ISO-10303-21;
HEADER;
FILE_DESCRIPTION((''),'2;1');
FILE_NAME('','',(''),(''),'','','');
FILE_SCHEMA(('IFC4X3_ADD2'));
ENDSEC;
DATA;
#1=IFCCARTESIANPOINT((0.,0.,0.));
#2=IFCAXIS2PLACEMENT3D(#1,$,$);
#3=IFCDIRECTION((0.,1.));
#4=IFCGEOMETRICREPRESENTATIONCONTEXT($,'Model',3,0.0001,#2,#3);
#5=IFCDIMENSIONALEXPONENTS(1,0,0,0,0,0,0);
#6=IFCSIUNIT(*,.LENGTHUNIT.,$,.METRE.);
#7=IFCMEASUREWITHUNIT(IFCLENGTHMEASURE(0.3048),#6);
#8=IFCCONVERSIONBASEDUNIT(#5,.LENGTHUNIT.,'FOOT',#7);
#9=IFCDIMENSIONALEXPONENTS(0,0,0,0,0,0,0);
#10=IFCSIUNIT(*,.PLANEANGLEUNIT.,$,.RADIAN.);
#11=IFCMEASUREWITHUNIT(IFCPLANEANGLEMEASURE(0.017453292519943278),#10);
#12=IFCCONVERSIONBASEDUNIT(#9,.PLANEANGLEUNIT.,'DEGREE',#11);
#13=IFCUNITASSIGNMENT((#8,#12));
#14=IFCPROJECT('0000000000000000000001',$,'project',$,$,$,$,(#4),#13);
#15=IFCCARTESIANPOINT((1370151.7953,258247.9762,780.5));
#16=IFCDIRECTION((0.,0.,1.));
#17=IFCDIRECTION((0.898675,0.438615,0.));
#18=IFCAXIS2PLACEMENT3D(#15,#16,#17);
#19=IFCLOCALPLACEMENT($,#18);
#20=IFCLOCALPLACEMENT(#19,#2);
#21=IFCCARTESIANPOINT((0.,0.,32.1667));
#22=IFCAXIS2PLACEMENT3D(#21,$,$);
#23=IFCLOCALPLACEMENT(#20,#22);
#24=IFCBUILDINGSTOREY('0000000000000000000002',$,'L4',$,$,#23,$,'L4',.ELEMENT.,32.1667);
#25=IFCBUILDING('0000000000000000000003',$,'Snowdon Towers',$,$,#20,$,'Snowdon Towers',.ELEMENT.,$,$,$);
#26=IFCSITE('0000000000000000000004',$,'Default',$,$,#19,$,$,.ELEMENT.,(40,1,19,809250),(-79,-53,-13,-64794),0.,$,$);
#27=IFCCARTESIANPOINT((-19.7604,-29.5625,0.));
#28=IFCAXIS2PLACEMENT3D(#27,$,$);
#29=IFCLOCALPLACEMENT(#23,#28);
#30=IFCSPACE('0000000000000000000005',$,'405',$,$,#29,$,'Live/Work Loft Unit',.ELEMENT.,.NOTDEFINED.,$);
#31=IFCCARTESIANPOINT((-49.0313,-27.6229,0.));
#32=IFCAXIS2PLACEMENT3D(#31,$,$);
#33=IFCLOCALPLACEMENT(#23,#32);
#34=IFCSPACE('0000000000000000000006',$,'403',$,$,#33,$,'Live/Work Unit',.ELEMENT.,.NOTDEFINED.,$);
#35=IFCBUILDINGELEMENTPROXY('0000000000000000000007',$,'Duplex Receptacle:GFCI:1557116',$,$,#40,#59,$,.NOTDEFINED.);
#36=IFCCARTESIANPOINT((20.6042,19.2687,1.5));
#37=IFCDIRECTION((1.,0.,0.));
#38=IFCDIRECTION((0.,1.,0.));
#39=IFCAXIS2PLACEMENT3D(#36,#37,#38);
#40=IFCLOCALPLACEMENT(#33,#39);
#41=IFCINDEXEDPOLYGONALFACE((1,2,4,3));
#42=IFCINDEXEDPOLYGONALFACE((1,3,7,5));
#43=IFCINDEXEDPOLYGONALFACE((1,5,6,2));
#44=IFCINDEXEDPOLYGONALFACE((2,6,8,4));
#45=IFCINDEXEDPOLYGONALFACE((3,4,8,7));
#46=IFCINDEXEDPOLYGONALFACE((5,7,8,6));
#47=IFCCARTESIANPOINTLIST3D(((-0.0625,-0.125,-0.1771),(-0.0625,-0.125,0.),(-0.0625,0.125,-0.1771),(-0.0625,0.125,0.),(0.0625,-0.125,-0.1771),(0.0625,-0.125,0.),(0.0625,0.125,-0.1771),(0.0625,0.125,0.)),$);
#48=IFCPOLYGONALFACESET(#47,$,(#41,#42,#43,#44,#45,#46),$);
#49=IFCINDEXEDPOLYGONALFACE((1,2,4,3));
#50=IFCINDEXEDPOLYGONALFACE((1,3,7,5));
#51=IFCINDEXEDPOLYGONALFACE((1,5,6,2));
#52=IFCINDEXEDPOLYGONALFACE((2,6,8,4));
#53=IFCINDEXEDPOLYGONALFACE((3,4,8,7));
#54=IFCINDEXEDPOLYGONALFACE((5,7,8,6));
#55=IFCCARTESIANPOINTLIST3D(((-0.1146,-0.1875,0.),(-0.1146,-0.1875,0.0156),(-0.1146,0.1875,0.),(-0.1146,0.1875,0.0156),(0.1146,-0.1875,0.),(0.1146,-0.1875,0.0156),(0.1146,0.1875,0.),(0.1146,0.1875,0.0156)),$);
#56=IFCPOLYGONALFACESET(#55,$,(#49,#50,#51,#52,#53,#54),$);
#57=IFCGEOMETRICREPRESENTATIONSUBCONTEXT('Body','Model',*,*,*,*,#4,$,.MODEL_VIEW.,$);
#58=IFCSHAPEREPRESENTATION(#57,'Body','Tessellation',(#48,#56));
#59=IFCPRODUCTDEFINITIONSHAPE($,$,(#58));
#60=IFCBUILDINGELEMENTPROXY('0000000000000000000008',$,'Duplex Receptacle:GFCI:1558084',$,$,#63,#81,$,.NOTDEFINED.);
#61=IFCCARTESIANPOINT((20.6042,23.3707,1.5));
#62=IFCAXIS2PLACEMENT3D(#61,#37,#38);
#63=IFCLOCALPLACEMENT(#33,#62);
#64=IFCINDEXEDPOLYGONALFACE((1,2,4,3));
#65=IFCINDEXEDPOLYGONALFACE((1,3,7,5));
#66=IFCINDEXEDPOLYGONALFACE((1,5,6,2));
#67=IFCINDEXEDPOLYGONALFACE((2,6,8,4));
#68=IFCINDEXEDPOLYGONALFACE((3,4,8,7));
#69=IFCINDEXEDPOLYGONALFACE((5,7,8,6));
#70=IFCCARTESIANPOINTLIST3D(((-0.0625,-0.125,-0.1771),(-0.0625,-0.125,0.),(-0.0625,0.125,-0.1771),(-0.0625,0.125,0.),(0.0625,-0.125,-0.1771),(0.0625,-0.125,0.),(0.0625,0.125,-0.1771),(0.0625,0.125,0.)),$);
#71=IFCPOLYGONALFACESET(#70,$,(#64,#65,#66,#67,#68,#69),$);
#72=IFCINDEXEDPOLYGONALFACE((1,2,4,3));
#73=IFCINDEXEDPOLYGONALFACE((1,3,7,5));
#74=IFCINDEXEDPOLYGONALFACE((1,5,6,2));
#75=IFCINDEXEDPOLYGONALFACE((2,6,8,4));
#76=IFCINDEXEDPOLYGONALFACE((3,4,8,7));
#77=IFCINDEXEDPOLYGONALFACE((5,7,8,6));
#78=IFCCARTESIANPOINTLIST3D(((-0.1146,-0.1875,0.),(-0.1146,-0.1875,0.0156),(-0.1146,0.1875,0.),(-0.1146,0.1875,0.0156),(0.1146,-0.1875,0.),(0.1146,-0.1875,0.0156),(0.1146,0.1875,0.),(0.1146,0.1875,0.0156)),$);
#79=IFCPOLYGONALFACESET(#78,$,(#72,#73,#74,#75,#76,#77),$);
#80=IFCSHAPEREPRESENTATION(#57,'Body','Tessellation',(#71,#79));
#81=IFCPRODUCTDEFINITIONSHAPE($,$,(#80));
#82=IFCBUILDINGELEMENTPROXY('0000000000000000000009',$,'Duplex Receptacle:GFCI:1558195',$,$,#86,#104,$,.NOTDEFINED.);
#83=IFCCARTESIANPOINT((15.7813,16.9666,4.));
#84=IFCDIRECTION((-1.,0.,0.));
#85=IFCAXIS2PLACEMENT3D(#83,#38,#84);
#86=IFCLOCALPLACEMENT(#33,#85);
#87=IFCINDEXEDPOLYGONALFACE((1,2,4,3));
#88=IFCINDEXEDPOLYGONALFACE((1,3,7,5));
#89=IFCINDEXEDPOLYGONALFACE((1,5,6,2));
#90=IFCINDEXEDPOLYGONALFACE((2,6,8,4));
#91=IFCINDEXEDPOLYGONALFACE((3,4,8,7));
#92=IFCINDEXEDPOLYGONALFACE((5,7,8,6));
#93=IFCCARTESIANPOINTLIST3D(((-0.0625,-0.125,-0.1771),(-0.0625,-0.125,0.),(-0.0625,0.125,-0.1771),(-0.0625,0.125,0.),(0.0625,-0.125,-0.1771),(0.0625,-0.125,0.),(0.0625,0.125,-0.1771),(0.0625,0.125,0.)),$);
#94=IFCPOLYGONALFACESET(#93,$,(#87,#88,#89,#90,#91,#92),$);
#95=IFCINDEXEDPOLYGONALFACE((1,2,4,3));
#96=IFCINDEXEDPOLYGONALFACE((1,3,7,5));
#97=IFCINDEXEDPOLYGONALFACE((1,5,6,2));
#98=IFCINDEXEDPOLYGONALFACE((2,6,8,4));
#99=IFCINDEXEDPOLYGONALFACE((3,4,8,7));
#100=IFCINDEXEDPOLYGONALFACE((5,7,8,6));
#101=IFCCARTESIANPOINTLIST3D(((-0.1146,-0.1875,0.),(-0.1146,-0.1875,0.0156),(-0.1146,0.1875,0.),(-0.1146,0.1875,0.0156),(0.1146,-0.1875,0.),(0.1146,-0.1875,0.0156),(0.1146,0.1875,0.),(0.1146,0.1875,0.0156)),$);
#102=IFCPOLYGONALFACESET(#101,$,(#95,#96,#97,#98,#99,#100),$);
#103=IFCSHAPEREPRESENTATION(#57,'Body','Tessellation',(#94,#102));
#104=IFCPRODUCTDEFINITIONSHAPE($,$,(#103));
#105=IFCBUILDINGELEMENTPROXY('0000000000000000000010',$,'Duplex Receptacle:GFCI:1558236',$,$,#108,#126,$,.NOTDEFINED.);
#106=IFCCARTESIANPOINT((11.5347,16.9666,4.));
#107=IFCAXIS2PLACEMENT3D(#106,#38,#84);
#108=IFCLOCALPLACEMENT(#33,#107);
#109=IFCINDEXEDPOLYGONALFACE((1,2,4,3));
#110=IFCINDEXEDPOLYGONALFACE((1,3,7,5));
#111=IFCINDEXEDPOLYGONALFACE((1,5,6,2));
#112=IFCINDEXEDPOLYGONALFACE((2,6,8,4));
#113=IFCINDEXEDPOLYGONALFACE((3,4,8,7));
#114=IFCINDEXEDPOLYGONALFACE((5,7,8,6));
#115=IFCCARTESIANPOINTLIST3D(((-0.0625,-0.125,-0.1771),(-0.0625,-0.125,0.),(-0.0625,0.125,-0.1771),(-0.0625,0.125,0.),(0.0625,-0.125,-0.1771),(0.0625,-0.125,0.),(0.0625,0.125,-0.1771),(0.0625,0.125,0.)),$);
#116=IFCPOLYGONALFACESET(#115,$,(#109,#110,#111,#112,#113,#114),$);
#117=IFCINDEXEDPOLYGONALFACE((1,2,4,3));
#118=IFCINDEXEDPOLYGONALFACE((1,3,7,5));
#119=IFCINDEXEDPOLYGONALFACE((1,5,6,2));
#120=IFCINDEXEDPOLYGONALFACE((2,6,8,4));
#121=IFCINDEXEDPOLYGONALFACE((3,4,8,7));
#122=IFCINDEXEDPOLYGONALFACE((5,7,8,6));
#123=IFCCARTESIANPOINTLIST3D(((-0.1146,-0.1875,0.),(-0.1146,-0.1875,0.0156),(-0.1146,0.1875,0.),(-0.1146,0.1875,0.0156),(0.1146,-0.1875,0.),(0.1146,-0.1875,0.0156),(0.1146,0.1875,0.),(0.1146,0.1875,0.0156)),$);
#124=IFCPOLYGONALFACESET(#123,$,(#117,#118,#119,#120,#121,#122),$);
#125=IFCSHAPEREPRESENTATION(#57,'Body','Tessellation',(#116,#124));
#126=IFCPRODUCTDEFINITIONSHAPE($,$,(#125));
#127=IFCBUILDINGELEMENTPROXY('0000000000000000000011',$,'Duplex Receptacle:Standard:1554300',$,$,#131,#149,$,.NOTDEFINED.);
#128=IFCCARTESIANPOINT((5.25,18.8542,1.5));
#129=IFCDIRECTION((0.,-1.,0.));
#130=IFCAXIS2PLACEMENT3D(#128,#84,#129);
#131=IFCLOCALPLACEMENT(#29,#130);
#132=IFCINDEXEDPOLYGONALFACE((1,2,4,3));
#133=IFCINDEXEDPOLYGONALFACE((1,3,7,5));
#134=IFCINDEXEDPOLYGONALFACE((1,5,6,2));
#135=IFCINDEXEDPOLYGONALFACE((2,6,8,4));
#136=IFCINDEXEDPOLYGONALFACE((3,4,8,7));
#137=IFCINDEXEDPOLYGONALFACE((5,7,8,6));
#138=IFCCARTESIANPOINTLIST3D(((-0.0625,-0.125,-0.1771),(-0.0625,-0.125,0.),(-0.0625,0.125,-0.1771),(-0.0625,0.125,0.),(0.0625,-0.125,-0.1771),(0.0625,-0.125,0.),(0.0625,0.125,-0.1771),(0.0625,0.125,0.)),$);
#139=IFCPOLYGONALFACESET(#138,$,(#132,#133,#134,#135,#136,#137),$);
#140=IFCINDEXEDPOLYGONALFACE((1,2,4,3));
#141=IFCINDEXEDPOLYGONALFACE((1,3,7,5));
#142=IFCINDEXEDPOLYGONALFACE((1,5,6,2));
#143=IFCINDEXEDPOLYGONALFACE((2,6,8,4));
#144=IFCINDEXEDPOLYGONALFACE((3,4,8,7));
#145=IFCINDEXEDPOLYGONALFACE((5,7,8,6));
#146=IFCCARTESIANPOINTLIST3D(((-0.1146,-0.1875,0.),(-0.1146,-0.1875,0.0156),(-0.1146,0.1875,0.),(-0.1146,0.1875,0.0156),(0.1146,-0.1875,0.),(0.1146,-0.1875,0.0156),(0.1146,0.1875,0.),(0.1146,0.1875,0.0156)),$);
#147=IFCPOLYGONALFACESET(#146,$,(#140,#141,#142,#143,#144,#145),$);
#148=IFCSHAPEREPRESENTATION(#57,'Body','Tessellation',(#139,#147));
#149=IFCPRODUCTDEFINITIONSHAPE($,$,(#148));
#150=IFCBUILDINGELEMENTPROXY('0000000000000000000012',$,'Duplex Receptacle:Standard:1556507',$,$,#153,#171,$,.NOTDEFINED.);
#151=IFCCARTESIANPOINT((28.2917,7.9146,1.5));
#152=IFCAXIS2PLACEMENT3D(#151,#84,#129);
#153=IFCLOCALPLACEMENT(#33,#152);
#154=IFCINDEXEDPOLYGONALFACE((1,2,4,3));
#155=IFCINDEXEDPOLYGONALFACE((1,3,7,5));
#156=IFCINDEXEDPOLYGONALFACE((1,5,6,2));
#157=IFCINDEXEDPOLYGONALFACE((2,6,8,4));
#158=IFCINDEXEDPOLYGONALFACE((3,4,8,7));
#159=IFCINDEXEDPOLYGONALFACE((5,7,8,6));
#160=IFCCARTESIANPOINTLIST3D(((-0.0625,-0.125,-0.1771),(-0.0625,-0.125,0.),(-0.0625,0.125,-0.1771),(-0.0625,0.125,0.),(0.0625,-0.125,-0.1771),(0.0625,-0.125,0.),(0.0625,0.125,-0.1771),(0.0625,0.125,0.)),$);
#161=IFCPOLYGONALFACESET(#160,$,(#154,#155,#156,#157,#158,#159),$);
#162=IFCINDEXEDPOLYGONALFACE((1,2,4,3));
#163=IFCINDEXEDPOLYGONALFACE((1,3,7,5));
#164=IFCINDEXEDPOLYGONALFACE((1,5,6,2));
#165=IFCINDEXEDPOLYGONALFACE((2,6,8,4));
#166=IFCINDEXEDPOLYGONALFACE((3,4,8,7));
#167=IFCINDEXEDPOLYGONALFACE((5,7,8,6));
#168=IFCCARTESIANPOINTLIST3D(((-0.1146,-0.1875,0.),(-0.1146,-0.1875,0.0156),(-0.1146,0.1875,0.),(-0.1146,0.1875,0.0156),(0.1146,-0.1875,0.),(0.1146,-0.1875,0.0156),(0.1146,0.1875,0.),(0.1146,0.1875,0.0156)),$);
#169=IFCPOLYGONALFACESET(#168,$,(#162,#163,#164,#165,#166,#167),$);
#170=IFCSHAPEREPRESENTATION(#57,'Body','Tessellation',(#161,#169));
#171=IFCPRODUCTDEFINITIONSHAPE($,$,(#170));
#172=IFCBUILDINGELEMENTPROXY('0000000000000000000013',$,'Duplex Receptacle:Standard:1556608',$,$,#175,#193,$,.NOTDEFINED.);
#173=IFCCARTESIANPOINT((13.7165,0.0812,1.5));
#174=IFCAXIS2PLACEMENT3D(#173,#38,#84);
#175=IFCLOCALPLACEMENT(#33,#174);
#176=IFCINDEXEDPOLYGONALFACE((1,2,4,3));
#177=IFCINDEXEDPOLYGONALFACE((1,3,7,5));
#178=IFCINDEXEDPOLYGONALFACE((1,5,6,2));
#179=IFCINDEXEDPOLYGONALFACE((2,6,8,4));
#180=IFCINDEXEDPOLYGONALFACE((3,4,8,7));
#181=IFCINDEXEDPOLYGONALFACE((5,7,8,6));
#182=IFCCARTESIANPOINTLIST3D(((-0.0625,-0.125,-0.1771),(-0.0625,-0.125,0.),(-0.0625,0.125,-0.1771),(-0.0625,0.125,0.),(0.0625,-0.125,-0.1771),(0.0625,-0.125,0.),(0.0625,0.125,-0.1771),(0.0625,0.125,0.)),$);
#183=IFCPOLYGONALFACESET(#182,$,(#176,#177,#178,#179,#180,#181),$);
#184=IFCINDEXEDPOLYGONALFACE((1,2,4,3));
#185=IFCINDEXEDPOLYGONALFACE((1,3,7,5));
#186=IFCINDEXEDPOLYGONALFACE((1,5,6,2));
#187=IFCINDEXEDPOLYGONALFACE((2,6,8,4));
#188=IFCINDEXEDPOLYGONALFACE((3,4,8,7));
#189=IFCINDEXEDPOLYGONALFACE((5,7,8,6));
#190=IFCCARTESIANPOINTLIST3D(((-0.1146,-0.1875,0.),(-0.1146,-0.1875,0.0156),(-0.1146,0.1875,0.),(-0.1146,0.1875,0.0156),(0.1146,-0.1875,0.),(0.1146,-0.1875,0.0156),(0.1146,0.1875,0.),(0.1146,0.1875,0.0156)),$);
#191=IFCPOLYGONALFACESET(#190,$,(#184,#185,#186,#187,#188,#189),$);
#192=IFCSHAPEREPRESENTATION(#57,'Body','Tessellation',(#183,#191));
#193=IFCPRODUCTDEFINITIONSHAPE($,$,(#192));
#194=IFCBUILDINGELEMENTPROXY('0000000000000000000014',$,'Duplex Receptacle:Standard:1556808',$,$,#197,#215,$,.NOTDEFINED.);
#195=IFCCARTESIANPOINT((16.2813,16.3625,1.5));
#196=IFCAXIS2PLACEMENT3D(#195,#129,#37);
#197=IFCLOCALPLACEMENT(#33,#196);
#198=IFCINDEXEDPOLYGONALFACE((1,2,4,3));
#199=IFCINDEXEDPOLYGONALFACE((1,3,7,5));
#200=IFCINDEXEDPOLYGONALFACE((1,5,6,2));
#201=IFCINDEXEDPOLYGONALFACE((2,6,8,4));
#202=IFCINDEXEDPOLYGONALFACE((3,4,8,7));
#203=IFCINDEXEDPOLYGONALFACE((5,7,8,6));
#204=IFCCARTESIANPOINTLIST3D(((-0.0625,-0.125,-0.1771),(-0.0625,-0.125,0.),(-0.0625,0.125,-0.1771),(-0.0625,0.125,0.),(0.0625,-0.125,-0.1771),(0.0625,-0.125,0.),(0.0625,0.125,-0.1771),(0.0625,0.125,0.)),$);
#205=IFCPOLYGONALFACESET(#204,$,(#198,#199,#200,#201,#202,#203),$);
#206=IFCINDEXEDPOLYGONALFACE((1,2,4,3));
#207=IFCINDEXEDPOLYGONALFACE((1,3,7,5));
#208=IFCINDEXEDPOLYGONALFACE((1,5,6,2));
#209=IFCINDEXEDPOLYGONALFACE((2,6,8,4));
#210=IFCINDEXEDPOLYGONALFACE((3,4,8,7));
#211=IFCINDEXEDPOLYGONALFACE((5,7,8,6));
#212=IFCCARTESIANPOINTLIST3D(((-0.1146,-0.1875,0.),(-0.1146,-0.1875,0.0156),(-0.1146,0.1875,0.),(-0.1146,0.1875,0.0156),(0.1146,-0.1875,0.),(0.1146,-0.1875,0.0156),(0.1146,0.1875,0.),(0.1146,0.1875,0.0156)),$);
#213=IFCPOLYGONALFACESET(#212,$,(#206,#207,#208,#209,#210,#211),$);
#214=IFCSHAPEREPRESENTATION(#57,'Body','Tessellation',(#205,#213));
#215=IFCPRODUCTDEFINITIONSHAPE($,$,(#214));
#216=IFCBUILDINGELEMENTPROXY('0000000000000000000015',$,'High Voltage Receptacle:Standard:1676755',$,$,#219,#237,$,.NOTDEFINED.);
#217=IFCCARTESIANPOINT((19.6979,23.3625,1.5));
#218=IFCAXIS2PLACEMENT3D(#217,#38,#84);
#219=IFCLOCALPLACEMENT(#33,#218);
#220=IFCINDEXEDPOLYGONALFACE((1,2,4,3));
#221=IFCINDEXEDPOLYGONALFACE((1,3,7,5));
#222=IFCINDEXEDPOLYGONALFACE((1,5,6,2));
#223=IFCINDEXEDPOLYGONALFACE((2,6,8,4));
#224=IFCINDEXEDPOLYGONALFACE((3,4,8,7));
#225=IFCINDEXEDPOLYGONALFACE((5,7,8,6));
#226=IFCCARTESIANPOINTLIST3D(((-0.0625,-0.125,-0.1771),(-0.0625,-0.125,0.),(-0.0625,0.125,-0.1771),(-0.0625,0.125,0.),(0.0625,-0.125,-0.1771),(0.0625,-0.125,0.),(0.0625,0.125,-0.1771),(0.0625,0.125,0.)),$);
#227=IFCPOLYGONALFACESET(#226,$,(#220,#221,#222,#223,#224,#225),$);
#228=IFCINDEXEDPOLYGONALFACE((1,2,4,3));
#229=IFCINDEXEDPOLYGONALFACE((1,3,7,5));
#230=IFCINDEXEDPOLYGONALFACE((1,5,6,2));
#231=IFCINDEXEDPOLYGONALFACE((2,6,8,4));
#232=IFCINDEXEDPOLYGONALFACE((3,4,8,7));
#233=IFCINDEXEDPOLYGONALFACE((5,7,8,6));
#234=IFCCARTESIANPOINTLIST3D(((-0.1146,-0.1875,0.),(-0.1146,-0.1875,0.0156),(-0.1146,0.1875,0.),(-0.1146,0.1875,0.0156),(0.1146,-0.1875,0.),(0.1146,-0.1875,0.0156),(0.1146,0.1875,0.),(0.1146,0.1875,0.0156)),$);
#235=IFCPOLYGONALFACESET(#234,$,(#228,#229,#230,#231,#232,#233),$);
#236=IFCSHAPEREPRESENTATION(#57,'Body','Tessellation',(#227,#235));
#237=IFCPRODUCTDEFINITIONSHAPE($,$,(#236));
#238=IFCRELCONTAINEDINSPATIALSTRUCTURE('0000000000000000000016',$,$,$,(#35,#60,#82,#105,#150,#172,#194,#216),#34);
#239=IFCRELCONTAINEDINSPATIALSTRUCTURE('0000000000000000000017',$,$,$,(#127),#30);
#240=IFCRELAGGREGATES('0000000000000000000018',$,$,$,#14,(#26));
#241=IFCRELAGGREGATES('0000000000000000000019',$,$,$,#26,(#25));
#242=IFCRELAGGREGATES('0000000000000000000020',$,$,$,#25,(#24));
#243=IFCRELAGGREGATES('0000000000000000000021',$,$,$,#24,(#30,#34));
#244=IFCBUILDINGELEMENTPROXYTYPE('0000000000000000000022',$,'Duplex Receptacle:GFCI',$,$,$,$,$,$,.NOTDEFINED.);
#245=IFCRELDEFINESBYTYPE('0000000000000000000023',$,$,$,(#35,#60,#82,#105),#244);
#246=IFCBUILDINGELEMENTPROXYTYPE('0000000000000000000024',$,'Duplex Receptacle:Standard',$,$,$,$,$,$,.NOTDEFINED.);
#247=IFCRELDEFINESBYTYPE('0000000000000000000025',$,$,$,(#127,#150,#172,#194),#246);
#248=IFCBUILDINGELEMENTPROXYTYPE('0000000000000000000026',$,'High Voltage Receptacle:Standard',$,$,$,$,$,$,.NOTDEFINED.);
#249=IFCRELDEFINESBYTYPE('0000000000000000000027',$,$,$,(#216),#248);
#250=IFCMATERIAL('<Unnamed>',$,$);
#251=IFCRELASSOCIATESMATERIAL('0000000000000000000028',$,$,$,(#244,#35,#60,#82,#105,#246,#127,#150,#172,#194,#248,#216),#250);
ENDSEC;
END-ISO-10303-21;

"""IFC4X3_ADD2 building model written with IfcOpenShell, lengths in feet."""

from ifc_helpers import new_model, entity, si_unit, converted_unit, direction, frame, frame_2d, origin, origin_2d_with_axis, place, context, subcontext, project, spatial, rectangle, extrude, source, transform, mapped, material, type_object, type_shapes, element, save


model = new_model("IFC4X3_ADD2")

# Units and contexts
model_context = context("Model", 3, precision=0.0001, world=origin(), true_north=direction((0.0, 1.0)))
body_context = subcontext(model_context, "Body", "Model", "MODEL_VIEW")
ifc_project = project(units=[converted_unit("LENGTHUNIT", "FOOT", entity("IfcLengthMeasure", 0.3048), si_unit("LENGTHUNIT", "METRE"), dimensions=[1, 0, 0, 0, 0, 0, 0]), converted_unit("PLANEANGLEUNIT", "DEGREE", entity("IfcPlaneAngleMeasure", 0.017453292519943278), si_unit("PLANEANGLEUNIT", "RADIAN"), dimensions=[0, 0, 0, 0, 0, 0, 0])], contexts=[model_context])

# Site, building, storey, space
site_placement = place(None, frame((1370151.7953, 258247.9762, 780.5), z_axis=(0.0, 0.0, 1.0), x_axis=(0.898675, 0.438615, 0.0)))
site = spatial("IfcSite", under=ifc_project, at=site_placement, Name="Default", CompositionType="ELEMENT", RefLatitude=(40, 1, 19, 809250), RefLongitude=(-79, -53, -13, -64794), RefElevation=0.0)
building_placement = place(site_placement, origin())
building = spatial("IfcBuilding", under=site, at=building_placement, Name="Snowdon Towers", LongName="Snowdon Towers", CompositionType="ELEMENT")
storey_placement = place(building_placement, frame((0.0, 0.0, 32.1667)))
storey = spatial("IfcBuildingStorey", under=building, at=storey_placement, Name="L4", LongName="L4", CompositionType="ELEMENT", Elevation=32.1667)
space_1_placement = place(storey_placement, frame((-19.7604, -29.5625, 0.0)))
space_1 = spatial("IfcSpace", under=storey, at=space_1_placement, Name="405", LongName="Live/Work Loft Unit", CompositionType="ELEMENT", PredefinedType="NOTDEFINED")

# Shared definitions
ifc_material_1 = material(Name="<Unnamed>")

# Shared definitions
space_2_placement = place(storey_placement, frame((-49.0313, -27.6229, 0.0)))
space_2 = spatial("IfcSpace", under=storey, at=space_2_placement, Name="403", LongName="Live/Work Unit", CompositionType="ELEMENT", PredefinedType="NOTDEFINED")

# Building element proxies
building_element_proxy_type_1 = type_object("IfcBuildingElementProxyType", Name="Duplex Receptacle:GFCI", PredefinedType="NOTDEFINED", material=ifc_material_1)
shared_shape_1 = source(origin(), body_context, "Body", "SweptSolid", [
    extrude(rectangle(XDim=0.125, YDim=0.25, at=origin_2d_with_axis()), frame((0.0, 0.0, -0.1771), z_axis=(0.0, 0.0, 1.0), x_axis=(-1.0, 0.0, 0.0)), (0.0, 0.0, 1.0), 0.1771),
    extrude(rectangle(XDim=0.2292, YDim=0.375, at=frame_2d((0.0, 0.0), x_axis=(1.0, 0.0))), frame((0.0, 0.0, 0.0), z_axis=(0.0, 0.0, 1.0), x_axis=(-1.0, 0.0, 0.0)), (0.0, 0.0, 1.0), 0.0156),
])
type_shapes(building_element_proxy_type_1, [shared_shape_1])
for number, where, z_axis, x_axis, name in (
    (1, (20.6042, 19.2687, 1.5), (1.0, 0.0, 0.0), (0.0, 1.0, 0.0), "Duplex Receptacle:GFCI:1557116"),
    (2, (20.6042, 23.3707, 1.5), (1.0, 0.0, 0.0), (0.0, 1.0, 0.0), "Duplex Receptacle:GFCI:1558084"),
    (3, (15.7813, 16.9666, 4.0), (0.0, 1.0, 0.0), (-1.0, 0.0, 0.0), "Duplex Receptacle:GFCI:1558195"),
    (4, (11.5347, 16.9666, 4.0), (0.0, 1.0, 0.0), (-1.0, 0.0, 0.0), "Duplex Receptacle:GFCI:1558236"),
):
    element("IfcBuildingElementProxy", number, at=place(space_2_placement, frame(where, z_axis=z_axis, x_axis=x_axis)), inside=space_2, type_object=building_element_proxy_type_1, material=ifc_material_1, Name=name, PredefinedType="NOTDEFINED", context=body_context, shape_type="MappedRepresentation", body=[
        mapped(shared_shape_1, transform((0.0, 0.0, 0.0), scale=1.0)),
    ])
building_element_proxy_type_2 = type_object("IfcBuildingElementProxyType", Name="Duplex Receptacle:Standard", PredefinedType="NOTDEFINED", material=ifc_material_1)
shared_shape_2 = source(origin(), body_context, "Body", "SweptSolid", [
    extrude(rectangle(XDim=0.125, YDim=0.25, at=origin_2d_with_axis()), frame((0.0, 0.0, -0.1771), z_axis=(0.0, 0.0, 1.0), x_axis=(-1.0, 0.0, 0.0)), (0.0, 0.0, 1.0), 0.1771),
    extrude(rectangle(XDim=0.2292, YDim=0.375, at=frame_2d((0.0, 0.0), x_axis=(1.0, 0.0))), frame((0.0, 0.0, 0.0), z_axis=(0.0, 0.0, 1.0), x_axis=(-1.0, 0.0, 0.0)), (0.0, 0.0, 1.0), 0.0156),
])
type_shapes(building_element_proxy_type_2, [shared_shape_2])
for number, where, z_axis, x_axis, name in (
    (5, (5.25, 18.8542, 1.5), (-1.0, 0.0, 0.0), (0.0, -1.0, 0.0), "Duplex Receptacle:Standard:1554300"),
):
    element("IfcBuildingElementProxy", number, at=place(space_1_placement, frame(where, z_axis=z_axis, x_axis=x_axis)), inside=space_1, type_object=building_element_proxy_type_2, material=ifc_material_1, Name=name, PredefinedType="NOTDEFINED", context=body_context, shape_type="MappedRepresentation", body=[
        mapped(shared_shape_2, transform((0.0, 0.0, 0.0), scale=1.0)),
    ])
for number, where, z_axis, x_axis, name in (
    (6, (28.2917, 7.9146, 1.5), (-1.0, 0.0, 0.0), (0.0, -1.0, 0.0), "Duplex Receptacle:Standard:1556507"),
    (7, (13.7165, 0.0812, 1.5), (0.0, 1.0, 0.0), (-1.0, 0.0, 0.0), "Duplex Receptacle:Standard:1556608"),
    (8, (16.2813, 16.3625, 1.5), (0.0, -1.0, 0.0), (1.0, 0.0, 0.0), "Duplex Receptacle:Standard:1556808"),
):
    element("IfcBuildingElementProxy", number, at=place(space_2_placement, frame(where, z_axis=z_axis, x_axis=x_axis)), inside=space_2, type_object=building_element_proxy_type_2, material=ifc_material_1, Name=name, PredefinedType="NOTDEFINED", context=body_context, shape_type="MappedRepresentation", body=[
        mapped(shared_shape_2, transform((0.0, 0.0, 0.0), scale=1.0)),
    ])
building_element_proxy_type_3 = type_object("IfcBuildingElementProxyType", Name="High Voltage Receptacle:Standard", PredefinedType="NOTDEFINED", material=ifc_material_1)
shared_shape_3 = source(origin(), body_context, "Body", "SweptSolid", [
    extrude(rectangle(XDim=0.125, YDim=0.25, at=origin_2d_with_axis()), frame((0.0, 0.0, -0.1771), z_axis=(0.0, 0.0, 1.0), x_axis=(-1.0, 0.0, 0.0)), (0.0, 0.0, 1.0), 0.1771),
    extrude(rectangle(XDim=0.2292, YDim=0.375, at=frame_2d((0.0, 0.0), x_axis=(1.0, 0.0))), frame((0.0, 0.0, 0.0), z_axis=(0.0, 0.0, 1.0), x_axis=(-1.0, 0.0, 0.0)), (0.0, 0.0, 1.0), 0.0156),
])
type_shapes(building_element_proxy_type_3, [shared_shape_3])
proxy_1_placement = place(space_2_placement, frame((19.6979, 23.3625, 1.5), z_axis=(0.0, 1.0, 0.0), x_axis=(-1.0, 0.0, 0.0)))
element("IfcBuildingElementProxy", 9, at=proxy_1_placement, inside=space_2, type_object=building_element_proxy_type_3, material=ifc_material_1, Name="High Voltage Receptacle:Standard:1676755", PredefinedType="NOTDEFINED", context=body_context, shape_type="MappedRepresentation", body=[
    mapped(shared_shape_3, transform((0.0, 0.0, 0.0), scale=1.0)),
])

save(model, "model.ifc")
